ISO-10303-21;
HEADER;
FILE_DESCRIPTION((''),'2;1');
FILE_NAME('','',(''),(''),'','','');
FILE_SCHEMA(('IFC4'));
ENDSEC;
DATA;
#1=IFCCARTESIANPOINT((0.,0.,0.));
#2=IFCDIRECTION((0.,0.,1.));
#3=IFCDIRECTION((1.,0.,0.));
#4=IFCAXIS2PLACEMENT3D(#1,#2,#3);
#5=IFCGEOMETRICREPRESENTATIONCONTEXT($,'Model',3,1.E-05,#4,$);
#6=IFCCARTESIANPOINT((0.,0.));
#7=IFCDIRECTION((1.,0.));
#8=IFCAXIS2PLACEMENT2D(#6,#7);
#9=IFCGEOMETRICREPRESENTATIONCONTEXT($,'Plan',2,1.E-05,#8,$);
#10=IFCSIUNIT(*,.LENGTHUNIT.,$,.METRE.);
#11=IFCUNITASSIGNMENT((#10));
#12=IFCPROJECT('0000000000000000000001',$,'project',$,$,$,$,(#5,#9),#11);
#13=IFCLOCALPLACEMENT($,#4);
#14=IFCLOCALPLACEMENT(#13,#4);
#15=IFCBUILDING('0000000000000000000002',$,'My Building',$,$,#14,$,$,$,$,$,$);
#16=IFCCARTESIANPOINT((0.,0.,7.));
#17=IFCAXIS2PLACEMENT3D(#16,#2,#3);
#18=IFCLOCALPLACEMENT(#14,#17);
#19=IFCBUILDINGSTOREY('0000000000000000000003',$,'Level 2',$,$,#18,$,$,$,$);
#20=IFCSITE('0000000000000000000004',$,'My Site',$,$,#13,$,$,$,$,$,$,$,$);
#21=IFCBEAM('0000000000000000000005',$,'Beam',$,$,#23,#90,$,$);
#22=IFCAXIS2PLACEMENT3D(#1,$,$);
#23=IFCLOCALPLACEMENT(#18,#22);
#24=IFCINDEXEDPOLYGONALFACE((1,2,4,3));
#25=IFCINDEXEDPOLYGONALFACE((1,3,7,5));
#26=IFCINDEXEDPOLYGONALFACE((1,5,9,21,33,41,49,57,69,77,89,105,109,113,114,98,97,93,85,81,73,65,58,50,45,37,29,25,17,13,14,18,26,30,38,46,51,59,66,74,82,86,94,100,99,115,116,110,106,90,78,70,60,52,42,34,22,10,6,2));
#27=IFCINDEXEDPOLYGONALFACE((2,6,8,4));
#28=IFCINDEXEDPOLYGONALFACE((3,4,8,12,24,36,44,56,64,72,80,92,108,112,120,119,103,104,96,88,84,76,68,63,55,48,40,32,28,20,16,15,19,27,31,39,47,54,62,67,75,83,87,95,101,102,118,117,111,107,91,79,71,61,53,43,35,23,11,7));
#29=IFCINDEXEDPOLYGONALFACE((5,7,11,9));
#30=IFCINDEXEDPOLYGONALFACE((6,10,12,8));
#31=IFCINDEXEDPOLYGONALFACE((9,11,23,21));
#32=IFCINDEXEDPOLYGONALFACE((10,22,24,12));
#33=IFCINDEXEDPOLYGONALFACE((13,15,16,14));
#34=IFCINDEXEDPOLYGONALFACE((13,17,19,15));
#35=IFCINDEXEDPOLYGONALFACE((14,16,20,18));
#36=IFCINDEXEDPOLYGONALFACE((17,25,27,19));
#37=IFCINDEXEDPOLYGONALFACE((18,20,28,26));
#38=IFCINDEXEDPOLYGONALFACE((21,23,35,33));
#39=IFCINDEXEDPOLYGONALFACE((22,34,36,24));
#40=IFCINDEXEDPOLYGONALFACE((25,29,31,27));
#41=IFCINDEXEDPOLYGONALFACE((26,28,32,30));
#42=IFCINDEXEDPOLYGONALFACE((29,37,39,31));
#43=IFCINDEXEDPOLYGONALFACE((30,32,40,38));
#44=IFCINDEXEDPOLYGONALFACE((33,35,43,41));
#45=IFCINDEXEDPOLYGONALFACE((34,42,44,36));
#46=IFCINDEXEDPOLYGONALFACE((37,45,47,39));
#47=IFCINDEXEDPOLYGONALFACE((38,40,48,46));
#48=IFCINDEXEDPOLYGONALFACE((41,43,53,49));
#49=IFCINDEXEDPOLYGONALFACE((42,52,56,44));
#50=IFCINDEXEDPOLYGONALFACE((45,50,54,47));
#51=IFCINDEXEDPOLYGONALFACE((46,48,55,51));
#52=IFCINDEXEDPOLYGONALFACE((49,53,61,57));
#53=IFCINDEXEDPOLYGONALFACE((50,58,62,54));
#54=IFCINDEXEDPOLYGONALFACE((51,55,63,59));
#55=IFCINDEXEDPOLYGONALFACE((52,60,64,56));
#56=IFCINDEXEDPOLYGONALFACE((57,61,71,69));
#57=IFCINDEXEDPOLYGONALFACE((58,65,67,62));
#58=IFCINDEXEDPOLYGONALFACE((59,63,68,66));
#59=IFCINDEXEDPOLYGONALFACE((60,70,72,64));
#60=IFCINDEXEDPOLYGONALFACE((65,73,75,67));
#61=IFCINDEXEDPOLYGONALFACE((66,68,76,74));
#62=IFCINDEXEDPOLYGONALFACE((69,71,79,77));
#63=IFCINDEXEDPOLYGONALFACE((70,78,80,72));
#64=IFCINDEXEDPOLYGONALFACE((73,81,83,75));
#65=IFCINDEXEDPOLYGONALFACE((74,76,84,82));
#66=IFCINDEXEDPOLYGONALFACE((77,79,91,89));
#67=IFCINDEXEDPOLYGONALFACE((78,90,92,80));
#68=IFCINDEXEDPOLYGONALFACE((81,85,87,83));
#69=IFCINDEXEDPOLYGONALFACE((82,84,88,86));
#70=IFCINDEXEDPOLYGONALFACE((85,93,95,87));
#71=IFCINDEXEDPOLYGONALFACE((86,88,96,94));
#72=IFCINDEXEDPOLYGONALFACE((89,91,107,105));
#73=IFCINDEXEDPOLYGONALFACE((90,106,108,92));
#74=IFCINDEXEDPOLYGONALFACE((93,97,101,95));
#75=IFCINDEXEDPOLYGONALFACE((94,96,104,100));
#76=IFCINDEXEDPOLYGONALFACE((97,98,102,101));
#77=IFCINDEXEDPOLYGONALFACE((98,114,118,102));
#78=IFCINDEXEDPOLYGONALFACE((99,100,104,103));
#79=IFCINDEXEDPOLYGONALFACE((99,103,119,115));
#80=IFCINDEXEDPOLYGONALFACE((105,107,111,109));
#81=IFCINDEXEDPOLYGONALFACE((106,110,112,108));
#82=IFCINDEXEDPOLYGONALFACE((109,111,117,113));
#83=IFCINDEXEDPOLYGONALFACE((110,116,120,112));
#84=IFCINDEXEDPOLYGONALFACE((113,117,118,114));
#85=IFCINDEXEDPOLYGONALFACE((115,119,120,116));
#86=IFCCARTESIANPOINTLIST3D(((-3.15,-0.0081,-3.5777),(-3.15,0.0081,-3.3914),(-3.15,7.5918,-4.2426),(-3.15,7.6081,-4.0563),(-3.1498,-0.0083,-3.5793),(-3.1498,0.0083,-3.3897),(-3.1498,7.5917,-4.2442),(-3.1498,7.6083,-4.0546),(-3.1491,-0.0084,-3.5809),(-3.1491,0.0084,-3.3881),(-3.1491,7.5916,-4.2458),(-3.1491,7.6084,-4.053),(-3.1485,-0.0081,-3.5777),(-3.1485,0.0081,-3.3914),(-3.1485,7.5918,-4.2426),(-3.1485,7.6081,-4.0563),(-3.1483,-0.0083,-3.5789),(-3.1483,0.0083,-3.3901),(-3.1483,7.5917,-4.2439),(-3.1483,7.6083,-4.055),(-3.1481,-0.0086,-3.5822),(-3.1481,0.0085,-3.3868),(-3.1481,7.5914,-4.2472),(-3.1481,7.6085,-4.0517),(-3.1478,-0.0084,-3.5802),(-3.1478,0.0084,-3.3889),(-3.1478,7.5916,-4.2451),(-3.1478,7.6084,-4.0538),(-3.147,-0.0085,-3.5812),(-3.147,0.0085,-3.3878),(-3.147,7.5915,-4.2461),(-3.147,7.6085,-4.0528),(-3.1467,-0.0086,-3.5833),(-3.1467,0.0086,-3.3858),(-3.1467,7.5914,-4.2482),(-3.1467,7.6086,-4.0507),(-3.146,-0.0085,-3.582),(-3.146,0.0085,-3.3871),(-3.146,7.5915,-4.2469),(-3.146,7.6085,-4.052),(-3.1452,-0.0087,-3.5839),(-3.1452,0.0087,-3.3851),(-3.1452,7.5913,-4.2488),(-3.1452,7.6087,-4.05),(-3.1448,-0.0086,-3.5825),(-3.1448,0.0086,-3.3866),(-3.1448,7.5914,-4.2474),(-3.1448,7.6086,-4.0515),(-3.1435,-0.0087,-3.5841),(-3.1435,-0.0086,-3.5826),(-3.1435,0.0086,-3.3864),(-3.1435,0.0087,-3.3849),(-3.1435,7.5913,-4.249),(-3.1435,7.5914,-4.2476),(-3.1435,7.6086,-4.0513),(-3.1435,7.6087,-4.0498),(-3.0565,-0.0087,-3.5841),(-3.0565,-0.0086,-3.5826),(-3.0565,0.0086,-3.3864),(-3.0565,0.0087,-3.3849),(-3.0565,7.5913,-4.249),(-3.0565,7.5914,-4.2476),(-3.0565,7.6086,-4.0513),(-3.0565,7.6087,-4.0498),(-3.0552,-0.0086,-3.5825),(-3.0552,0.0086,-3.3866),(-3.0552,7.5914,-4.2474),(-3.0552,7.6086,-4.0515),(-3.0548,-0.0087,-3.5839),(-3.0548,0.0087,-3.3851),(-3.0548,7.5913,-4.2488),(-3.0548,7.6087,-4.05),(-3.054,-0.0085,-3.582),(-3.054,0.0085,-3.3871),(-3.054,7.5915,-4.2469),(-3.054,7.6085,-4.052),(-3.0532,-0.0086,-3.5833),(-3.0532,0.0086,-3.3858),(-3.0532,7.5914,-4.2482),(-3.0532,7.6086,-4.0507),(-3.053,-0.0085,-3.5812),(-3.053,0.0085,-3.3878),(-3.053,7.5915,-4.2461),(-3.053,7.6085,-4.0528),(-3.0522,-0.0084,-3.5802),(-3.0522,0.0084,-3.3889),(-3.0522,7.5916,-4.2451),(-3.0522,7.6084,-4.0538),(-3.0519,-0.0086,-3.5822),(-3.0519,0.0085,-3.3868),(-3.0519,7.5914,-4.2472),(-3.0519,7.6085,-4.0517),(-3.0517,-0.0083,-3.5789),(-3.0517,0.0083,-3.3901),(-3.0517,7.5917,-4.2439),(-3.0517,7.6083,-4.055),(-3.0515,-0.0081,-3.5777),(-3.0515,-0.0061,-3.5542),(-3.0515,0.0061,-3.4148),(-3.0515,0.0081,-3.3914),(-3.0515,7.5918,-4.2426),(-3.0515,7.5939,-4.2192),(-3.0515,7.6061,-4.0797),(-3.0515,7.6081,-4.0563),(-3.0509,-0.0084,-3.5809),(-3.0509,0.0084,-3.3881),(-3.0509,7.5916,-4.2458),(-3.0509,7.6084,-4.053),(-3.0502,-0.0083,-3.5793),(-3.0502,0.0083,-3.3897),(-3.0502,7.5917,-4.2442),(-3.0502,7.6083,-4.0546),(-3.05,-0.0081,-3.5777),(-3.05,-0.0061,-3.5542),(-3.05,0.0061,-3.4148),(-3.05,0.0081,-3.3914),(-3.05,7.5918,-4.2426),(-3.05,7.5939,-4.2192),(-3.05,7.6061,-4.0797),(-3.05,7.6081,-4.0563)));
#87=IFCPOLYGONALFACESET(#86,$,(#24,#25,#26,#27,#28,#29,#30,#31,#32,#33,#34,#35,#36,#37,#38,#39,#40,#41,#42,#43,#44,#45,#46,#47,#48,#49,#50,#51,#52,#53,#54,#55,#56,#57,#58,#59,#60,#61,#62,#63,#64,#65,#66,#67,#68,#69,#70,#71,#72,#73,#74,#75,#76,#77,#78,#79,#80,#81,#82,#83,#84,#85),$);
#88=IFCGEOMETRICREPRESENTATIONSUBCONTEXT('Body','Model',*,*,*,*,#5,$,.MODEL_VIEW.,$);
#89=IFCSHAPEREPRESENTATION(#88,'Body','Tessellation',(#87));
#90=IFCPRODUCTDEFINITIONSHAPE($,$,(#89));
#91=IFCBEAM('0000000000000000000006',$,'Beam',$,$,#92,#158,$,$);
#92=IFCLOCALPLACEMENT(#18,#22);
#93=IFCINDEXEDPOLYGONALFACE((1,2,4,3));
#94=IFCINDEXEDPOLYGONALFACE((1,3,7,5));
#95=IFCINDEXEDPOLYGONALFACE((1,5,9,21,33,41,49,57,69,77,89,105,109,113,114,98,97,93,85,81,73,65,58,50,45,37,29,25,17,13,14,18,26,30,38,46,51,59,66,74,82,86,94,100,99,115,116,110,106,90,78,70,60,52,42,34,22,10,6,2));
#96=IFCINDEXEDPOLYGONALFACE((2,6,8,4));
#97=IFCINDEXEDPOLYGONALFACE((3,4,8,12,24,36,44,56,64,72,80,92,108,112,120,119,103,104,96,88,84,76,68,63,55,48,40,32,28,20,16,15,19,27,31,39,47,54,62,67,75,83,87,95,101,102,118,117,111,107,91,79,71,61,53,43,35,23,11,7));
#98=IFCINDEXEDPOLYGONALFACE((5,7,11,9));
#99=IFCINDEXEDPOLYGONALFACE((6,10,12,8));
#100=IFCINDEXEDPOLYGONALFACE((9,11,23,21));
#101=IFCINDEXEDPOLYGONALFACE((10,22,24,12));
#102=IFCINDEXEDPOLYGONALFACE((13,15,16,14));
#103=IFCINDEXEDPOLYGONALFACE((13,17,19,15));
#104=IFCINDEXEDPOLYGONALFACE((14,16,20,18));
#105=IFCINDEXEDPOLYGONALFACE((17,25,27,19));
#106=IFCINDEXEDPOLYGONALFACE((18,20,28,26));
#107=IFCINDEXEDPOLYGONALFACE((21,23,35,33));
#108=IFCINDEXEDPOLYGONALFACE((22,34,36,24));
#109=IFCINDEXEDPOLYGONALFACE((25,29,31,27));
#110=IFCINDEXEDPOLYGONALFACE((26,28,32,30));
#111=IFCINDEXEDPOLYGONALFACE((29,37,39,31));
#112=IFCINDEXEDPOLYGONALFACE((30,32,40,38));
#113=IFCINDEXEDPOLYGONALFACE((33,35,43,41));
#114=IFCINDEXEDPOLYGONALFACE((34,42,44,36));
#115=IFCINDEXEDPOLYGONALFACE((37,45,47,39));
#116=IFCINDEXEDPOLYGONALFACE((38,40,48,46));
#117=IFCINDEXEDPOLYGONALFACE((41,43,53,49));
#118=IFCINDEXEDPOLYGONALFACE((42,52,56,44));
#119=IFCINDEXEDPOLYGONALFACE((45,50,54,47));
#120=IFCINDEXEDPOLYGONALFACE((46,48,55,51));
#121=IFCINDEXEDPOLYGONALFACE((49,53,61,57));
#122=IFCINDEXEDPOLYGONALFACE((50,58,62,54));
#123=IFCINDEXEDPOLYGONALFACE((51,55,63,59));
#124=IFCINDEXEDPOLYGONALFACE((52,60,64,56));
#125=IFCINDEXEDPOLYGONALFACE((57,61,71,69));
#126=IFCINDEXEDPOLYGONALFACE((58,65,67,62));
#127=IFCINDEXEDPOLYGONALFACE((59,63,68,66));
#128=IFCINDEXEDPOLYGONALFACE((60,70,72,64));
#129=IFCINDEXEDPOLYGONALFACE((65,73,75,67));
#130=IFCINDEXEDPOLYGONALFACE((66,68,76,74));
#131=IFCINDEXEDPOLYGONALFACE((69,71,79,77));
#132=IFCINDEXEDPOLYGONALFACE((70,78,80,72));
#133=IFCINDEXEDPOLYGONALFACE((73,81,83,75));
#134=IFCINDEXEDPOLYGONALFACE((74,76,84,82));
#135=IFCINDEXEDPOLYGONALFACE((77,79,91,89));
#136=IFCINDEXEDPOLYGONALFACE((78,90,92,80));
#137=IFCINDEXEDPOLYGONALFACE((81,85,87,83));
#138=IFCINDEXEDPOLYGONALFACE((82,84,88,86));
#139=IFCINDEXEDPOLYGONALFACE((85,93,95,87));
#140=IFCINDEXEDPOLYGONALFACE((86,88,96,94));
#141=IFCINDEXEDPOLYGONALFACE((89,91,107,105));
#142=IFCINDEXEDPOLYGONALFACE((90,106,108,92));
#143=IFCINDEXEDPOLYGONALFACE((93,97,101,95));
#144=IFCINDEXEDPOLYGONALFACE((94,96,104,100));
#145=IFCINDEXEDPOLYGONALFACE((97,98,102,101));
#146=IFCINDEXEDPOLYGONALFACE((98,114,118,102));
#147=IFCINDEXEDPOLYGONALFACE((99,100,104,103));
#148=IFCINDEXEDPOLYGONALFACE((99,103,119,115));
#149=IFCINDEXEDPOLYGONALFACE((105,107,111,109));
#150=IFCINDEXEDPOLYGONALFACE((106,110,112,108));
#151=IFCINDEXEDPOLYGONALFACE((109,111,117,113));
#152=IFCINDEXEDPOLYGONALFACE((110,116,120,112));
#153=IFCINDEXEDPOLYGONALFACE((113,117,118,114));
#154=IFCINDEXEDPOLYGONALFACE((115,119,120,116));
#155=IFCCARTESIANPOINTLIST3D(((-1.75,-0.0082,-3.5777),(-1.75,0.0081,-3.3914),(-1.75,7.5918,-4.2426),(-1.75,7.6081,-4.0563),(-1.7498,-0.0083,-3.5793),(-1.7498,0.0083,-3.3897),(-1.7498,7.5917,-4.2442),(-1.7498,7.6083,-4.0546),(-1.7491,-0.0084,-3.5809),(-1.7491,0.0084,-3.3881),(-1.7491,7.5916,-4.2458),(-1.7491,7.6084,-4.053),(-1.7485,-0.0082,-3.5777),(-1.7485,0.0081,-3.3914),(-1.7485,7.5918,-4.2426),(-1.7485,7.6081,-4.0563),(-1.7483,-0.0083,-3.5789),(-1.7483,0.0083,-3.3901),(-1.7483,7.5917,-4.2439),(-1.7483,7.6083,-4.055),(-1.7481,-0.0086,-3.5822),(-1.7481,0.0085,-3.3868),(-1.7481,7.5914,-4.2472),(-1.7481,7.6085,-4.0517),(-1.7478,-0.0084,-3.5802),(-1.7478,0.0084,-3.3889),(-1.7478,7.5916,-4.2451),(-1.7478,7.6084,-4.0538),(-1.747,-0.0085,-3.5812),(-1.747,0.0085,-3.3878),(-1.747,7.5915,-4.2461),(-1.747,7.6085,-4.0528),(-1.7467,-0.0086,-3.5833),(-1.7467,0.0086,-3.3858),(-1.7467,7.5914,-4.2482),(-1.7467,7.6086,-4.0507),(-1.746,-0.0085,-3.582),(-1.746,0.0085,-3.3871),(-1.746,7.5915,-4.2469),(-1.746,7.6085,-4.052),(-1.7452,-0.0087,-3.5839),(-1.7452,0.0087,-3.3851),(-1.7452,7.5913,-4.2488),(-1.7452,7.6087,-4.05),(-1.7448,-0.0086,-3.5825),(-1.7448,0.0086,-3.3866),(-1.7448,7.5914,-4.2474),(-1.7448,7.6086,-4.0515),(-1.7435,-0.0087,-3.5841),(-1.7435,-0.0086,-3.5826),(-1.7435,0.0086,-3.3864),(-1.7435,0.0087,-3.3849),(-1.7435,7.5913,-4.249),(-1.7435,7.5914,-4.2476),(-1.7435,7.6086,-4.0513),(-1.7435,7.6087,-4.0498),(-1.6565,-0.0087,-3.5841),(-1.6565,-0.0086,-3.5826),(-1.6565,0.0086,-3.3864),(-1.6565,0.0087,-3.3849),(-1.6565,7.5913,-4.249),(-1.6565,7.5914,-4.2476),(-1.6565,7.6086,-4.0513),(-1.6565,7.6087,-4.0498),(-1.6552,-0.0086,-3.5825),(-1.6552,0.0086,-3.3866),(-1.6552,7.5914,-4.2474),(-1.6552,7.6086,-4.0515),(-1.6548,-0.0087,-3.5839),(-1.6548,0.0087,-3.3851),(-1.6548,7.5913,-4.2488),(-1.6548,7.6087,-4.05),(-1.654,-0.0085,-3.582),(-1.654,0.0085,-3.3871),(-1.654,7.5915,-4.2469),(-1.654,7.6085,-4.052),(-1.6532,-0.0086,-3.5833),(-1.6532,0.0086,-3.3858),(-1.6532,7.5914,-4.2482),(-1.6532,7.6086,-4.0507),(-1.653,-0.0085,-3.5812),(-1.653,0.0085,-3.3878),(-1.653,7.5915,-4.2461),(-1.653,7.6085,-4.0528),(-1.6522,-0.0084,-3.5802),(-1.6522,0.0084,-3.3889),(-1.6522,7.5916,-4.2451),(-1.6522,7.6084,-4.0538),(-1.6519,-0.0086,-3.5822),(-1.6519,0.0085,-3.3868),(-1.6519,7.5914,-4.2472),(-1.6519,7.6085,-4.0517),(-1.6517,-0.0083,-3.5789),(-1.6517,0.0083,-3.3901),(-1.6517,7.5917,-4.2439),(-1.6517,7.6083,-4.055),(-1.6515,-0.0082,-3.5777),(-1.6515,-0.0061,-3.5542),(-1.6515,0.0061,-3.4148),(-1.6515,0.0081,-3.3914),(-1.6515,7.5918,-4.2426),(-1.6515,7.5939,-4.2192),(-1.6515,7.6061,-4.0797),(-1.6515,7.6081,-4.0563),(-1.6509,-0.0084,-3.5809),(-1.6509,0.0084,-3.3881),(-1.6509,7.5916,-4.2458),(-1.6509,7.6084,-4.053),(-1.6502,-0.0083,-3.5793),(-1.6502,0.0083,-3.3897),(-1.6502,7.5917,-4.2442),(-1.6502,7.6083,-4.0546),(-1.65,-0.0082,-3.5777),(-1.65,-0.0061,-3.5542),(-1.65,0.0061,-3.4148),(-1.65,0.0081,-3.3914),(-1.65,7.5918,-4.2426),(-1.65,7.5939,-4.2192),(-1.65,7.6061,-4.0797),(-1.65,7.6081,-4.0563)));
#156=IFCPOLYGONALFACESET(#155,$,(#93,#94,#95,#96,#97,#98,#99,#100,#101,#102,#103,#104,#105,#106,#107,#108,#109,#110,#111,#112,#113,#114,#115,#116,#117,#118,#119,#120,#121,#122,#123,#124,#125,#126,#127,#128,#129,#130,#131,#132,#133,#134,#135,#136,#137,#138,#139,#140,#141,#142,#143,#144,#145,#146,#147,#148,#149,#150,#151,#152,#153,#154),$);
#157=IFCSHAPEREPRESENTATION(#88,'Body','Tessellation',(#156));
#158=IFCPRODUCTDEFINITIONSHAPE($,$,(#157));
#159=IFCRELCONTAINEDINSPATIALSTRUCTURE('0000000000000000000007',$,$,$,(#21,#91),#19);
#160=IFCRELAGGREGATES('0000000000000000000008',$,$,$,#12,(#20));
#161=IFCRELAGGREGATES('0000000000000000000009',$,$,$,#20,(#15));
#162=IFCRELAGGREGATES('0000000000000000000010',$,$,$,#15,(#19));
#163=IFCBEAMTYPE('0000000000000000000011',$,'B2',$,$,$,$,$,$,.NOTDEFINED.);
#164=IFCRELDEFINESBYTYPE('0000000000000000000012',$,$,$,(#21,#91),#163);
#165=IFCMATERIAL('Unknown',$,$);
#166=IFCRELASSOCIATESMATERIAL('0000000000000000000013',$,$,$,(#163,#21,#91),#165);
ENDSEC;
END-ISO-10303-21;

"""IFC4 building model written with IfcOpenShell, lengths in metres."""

from ifc_helpers import new_model, si_unit, frame, origin_with_axes, origin_2d_with_axis, place, context, subcontext, project, spatial, c_section, extrude, material, material_profile, profile_set, profile_usage, type_object, element, save


model = new_model("IFC4")

# Units and contexts
model_context = context("Model", 3, precision=1e-05, world=origin_with_axes())
plan_context = context("Plan", 2, precision=1e-05, world=origin_2d_with_axis())
body_context = subcontext(model_context, "Body", "Model", "MODEL_VIEW")
ifc_project = project(units=[si_unit("LENGTHUNIT", "METRE")], contexts=[model_context, plan_context])

# Site, building, storey
site_placement = place(None, origin_with_axes())
site = spatial("IfcSite", under=ifc_project, at=site_placement, Name="My Site")
building_placement = place(site_placement, origin_with_axes())
building = spatial("IfcBuilding", under=site, at=building_placement, Name="My Building")
storey_placement = place(building_placement, frame((0.0, 0.0, 7.0), z_axis=(0.0, 0.0, 1.0), x_axis=(1.0, 0.0, 0.0)))
storey = spatial("IfcBuildingStorey", under=building, at=storey_placement, Name="Level 2")

# Shared definitions
ifc_material = material(Name="Unknown")

# Beams
ifc_material_profile_1 = material_profile(ifc_material, c_section(Depth=0.2, Width=0.1, WallThickness=0.0015, Girth=0.03, InternalFilletRadius=0.005))
ifc_profile_set_1 = profile_set([ifc_material_profile_1])
beam_type_1 = type_object("IfcBeamType", Name="B2", PredefinedType="NOTDEFINED", material=ifc_profile_set_1)
ifc_profile_usage_1 = profile_usage(ifc_profile_set_1, cardinal=5)
beam_1_placement = place(storey_placement, frame((-3.1, 7.6, -4.1494), z_axis=(0.0, -0.996195, 0.087156), x_axis=(1.0, 0.0, 0.0)))
element("IfcBeam", 1, at=beam_1_placement, inside=storey, type_object=beam_type_1, material=ifc_profile_usage_1, Name="Beam", context=body_context, shape_type="SweptSolid", body=[
    extrude(c_section(Depth=0.2, Width=0.1, WallThickness=0.0015, Girth=0.03, InternalFilletRadius=0.005), origin_with_axes(), (0.0, 0.0, 1.0), 7.629),
])
ifc_profile_usage_2 = profile_usage(ifc_profile_set_1, cardinal=5)
beam_2_placement = place(storey_placement, frame((-1.7, 7.6, -4.1494), z_axis=(0.0, -0.996195, 0.087156), x_axis=(1.0, 0.0, 0.0)))
element("IfcBeam", 2, at=beam_2_placement, inside=storey, type_object=beam_type_1, material=ifc_profile_usage_2, Name="Beam", context=body_context, shape_type="SweptSolid", body=[
    extrude(c_section(Depth=0.2, Width=0.1, WallThickness=0.0015, Girth=0.03, InternalFilletRadius=0.005), origin_with_axes(), (0.0, 0.0, 1.0), 7.629),
])

save(model, "model.ifc")
